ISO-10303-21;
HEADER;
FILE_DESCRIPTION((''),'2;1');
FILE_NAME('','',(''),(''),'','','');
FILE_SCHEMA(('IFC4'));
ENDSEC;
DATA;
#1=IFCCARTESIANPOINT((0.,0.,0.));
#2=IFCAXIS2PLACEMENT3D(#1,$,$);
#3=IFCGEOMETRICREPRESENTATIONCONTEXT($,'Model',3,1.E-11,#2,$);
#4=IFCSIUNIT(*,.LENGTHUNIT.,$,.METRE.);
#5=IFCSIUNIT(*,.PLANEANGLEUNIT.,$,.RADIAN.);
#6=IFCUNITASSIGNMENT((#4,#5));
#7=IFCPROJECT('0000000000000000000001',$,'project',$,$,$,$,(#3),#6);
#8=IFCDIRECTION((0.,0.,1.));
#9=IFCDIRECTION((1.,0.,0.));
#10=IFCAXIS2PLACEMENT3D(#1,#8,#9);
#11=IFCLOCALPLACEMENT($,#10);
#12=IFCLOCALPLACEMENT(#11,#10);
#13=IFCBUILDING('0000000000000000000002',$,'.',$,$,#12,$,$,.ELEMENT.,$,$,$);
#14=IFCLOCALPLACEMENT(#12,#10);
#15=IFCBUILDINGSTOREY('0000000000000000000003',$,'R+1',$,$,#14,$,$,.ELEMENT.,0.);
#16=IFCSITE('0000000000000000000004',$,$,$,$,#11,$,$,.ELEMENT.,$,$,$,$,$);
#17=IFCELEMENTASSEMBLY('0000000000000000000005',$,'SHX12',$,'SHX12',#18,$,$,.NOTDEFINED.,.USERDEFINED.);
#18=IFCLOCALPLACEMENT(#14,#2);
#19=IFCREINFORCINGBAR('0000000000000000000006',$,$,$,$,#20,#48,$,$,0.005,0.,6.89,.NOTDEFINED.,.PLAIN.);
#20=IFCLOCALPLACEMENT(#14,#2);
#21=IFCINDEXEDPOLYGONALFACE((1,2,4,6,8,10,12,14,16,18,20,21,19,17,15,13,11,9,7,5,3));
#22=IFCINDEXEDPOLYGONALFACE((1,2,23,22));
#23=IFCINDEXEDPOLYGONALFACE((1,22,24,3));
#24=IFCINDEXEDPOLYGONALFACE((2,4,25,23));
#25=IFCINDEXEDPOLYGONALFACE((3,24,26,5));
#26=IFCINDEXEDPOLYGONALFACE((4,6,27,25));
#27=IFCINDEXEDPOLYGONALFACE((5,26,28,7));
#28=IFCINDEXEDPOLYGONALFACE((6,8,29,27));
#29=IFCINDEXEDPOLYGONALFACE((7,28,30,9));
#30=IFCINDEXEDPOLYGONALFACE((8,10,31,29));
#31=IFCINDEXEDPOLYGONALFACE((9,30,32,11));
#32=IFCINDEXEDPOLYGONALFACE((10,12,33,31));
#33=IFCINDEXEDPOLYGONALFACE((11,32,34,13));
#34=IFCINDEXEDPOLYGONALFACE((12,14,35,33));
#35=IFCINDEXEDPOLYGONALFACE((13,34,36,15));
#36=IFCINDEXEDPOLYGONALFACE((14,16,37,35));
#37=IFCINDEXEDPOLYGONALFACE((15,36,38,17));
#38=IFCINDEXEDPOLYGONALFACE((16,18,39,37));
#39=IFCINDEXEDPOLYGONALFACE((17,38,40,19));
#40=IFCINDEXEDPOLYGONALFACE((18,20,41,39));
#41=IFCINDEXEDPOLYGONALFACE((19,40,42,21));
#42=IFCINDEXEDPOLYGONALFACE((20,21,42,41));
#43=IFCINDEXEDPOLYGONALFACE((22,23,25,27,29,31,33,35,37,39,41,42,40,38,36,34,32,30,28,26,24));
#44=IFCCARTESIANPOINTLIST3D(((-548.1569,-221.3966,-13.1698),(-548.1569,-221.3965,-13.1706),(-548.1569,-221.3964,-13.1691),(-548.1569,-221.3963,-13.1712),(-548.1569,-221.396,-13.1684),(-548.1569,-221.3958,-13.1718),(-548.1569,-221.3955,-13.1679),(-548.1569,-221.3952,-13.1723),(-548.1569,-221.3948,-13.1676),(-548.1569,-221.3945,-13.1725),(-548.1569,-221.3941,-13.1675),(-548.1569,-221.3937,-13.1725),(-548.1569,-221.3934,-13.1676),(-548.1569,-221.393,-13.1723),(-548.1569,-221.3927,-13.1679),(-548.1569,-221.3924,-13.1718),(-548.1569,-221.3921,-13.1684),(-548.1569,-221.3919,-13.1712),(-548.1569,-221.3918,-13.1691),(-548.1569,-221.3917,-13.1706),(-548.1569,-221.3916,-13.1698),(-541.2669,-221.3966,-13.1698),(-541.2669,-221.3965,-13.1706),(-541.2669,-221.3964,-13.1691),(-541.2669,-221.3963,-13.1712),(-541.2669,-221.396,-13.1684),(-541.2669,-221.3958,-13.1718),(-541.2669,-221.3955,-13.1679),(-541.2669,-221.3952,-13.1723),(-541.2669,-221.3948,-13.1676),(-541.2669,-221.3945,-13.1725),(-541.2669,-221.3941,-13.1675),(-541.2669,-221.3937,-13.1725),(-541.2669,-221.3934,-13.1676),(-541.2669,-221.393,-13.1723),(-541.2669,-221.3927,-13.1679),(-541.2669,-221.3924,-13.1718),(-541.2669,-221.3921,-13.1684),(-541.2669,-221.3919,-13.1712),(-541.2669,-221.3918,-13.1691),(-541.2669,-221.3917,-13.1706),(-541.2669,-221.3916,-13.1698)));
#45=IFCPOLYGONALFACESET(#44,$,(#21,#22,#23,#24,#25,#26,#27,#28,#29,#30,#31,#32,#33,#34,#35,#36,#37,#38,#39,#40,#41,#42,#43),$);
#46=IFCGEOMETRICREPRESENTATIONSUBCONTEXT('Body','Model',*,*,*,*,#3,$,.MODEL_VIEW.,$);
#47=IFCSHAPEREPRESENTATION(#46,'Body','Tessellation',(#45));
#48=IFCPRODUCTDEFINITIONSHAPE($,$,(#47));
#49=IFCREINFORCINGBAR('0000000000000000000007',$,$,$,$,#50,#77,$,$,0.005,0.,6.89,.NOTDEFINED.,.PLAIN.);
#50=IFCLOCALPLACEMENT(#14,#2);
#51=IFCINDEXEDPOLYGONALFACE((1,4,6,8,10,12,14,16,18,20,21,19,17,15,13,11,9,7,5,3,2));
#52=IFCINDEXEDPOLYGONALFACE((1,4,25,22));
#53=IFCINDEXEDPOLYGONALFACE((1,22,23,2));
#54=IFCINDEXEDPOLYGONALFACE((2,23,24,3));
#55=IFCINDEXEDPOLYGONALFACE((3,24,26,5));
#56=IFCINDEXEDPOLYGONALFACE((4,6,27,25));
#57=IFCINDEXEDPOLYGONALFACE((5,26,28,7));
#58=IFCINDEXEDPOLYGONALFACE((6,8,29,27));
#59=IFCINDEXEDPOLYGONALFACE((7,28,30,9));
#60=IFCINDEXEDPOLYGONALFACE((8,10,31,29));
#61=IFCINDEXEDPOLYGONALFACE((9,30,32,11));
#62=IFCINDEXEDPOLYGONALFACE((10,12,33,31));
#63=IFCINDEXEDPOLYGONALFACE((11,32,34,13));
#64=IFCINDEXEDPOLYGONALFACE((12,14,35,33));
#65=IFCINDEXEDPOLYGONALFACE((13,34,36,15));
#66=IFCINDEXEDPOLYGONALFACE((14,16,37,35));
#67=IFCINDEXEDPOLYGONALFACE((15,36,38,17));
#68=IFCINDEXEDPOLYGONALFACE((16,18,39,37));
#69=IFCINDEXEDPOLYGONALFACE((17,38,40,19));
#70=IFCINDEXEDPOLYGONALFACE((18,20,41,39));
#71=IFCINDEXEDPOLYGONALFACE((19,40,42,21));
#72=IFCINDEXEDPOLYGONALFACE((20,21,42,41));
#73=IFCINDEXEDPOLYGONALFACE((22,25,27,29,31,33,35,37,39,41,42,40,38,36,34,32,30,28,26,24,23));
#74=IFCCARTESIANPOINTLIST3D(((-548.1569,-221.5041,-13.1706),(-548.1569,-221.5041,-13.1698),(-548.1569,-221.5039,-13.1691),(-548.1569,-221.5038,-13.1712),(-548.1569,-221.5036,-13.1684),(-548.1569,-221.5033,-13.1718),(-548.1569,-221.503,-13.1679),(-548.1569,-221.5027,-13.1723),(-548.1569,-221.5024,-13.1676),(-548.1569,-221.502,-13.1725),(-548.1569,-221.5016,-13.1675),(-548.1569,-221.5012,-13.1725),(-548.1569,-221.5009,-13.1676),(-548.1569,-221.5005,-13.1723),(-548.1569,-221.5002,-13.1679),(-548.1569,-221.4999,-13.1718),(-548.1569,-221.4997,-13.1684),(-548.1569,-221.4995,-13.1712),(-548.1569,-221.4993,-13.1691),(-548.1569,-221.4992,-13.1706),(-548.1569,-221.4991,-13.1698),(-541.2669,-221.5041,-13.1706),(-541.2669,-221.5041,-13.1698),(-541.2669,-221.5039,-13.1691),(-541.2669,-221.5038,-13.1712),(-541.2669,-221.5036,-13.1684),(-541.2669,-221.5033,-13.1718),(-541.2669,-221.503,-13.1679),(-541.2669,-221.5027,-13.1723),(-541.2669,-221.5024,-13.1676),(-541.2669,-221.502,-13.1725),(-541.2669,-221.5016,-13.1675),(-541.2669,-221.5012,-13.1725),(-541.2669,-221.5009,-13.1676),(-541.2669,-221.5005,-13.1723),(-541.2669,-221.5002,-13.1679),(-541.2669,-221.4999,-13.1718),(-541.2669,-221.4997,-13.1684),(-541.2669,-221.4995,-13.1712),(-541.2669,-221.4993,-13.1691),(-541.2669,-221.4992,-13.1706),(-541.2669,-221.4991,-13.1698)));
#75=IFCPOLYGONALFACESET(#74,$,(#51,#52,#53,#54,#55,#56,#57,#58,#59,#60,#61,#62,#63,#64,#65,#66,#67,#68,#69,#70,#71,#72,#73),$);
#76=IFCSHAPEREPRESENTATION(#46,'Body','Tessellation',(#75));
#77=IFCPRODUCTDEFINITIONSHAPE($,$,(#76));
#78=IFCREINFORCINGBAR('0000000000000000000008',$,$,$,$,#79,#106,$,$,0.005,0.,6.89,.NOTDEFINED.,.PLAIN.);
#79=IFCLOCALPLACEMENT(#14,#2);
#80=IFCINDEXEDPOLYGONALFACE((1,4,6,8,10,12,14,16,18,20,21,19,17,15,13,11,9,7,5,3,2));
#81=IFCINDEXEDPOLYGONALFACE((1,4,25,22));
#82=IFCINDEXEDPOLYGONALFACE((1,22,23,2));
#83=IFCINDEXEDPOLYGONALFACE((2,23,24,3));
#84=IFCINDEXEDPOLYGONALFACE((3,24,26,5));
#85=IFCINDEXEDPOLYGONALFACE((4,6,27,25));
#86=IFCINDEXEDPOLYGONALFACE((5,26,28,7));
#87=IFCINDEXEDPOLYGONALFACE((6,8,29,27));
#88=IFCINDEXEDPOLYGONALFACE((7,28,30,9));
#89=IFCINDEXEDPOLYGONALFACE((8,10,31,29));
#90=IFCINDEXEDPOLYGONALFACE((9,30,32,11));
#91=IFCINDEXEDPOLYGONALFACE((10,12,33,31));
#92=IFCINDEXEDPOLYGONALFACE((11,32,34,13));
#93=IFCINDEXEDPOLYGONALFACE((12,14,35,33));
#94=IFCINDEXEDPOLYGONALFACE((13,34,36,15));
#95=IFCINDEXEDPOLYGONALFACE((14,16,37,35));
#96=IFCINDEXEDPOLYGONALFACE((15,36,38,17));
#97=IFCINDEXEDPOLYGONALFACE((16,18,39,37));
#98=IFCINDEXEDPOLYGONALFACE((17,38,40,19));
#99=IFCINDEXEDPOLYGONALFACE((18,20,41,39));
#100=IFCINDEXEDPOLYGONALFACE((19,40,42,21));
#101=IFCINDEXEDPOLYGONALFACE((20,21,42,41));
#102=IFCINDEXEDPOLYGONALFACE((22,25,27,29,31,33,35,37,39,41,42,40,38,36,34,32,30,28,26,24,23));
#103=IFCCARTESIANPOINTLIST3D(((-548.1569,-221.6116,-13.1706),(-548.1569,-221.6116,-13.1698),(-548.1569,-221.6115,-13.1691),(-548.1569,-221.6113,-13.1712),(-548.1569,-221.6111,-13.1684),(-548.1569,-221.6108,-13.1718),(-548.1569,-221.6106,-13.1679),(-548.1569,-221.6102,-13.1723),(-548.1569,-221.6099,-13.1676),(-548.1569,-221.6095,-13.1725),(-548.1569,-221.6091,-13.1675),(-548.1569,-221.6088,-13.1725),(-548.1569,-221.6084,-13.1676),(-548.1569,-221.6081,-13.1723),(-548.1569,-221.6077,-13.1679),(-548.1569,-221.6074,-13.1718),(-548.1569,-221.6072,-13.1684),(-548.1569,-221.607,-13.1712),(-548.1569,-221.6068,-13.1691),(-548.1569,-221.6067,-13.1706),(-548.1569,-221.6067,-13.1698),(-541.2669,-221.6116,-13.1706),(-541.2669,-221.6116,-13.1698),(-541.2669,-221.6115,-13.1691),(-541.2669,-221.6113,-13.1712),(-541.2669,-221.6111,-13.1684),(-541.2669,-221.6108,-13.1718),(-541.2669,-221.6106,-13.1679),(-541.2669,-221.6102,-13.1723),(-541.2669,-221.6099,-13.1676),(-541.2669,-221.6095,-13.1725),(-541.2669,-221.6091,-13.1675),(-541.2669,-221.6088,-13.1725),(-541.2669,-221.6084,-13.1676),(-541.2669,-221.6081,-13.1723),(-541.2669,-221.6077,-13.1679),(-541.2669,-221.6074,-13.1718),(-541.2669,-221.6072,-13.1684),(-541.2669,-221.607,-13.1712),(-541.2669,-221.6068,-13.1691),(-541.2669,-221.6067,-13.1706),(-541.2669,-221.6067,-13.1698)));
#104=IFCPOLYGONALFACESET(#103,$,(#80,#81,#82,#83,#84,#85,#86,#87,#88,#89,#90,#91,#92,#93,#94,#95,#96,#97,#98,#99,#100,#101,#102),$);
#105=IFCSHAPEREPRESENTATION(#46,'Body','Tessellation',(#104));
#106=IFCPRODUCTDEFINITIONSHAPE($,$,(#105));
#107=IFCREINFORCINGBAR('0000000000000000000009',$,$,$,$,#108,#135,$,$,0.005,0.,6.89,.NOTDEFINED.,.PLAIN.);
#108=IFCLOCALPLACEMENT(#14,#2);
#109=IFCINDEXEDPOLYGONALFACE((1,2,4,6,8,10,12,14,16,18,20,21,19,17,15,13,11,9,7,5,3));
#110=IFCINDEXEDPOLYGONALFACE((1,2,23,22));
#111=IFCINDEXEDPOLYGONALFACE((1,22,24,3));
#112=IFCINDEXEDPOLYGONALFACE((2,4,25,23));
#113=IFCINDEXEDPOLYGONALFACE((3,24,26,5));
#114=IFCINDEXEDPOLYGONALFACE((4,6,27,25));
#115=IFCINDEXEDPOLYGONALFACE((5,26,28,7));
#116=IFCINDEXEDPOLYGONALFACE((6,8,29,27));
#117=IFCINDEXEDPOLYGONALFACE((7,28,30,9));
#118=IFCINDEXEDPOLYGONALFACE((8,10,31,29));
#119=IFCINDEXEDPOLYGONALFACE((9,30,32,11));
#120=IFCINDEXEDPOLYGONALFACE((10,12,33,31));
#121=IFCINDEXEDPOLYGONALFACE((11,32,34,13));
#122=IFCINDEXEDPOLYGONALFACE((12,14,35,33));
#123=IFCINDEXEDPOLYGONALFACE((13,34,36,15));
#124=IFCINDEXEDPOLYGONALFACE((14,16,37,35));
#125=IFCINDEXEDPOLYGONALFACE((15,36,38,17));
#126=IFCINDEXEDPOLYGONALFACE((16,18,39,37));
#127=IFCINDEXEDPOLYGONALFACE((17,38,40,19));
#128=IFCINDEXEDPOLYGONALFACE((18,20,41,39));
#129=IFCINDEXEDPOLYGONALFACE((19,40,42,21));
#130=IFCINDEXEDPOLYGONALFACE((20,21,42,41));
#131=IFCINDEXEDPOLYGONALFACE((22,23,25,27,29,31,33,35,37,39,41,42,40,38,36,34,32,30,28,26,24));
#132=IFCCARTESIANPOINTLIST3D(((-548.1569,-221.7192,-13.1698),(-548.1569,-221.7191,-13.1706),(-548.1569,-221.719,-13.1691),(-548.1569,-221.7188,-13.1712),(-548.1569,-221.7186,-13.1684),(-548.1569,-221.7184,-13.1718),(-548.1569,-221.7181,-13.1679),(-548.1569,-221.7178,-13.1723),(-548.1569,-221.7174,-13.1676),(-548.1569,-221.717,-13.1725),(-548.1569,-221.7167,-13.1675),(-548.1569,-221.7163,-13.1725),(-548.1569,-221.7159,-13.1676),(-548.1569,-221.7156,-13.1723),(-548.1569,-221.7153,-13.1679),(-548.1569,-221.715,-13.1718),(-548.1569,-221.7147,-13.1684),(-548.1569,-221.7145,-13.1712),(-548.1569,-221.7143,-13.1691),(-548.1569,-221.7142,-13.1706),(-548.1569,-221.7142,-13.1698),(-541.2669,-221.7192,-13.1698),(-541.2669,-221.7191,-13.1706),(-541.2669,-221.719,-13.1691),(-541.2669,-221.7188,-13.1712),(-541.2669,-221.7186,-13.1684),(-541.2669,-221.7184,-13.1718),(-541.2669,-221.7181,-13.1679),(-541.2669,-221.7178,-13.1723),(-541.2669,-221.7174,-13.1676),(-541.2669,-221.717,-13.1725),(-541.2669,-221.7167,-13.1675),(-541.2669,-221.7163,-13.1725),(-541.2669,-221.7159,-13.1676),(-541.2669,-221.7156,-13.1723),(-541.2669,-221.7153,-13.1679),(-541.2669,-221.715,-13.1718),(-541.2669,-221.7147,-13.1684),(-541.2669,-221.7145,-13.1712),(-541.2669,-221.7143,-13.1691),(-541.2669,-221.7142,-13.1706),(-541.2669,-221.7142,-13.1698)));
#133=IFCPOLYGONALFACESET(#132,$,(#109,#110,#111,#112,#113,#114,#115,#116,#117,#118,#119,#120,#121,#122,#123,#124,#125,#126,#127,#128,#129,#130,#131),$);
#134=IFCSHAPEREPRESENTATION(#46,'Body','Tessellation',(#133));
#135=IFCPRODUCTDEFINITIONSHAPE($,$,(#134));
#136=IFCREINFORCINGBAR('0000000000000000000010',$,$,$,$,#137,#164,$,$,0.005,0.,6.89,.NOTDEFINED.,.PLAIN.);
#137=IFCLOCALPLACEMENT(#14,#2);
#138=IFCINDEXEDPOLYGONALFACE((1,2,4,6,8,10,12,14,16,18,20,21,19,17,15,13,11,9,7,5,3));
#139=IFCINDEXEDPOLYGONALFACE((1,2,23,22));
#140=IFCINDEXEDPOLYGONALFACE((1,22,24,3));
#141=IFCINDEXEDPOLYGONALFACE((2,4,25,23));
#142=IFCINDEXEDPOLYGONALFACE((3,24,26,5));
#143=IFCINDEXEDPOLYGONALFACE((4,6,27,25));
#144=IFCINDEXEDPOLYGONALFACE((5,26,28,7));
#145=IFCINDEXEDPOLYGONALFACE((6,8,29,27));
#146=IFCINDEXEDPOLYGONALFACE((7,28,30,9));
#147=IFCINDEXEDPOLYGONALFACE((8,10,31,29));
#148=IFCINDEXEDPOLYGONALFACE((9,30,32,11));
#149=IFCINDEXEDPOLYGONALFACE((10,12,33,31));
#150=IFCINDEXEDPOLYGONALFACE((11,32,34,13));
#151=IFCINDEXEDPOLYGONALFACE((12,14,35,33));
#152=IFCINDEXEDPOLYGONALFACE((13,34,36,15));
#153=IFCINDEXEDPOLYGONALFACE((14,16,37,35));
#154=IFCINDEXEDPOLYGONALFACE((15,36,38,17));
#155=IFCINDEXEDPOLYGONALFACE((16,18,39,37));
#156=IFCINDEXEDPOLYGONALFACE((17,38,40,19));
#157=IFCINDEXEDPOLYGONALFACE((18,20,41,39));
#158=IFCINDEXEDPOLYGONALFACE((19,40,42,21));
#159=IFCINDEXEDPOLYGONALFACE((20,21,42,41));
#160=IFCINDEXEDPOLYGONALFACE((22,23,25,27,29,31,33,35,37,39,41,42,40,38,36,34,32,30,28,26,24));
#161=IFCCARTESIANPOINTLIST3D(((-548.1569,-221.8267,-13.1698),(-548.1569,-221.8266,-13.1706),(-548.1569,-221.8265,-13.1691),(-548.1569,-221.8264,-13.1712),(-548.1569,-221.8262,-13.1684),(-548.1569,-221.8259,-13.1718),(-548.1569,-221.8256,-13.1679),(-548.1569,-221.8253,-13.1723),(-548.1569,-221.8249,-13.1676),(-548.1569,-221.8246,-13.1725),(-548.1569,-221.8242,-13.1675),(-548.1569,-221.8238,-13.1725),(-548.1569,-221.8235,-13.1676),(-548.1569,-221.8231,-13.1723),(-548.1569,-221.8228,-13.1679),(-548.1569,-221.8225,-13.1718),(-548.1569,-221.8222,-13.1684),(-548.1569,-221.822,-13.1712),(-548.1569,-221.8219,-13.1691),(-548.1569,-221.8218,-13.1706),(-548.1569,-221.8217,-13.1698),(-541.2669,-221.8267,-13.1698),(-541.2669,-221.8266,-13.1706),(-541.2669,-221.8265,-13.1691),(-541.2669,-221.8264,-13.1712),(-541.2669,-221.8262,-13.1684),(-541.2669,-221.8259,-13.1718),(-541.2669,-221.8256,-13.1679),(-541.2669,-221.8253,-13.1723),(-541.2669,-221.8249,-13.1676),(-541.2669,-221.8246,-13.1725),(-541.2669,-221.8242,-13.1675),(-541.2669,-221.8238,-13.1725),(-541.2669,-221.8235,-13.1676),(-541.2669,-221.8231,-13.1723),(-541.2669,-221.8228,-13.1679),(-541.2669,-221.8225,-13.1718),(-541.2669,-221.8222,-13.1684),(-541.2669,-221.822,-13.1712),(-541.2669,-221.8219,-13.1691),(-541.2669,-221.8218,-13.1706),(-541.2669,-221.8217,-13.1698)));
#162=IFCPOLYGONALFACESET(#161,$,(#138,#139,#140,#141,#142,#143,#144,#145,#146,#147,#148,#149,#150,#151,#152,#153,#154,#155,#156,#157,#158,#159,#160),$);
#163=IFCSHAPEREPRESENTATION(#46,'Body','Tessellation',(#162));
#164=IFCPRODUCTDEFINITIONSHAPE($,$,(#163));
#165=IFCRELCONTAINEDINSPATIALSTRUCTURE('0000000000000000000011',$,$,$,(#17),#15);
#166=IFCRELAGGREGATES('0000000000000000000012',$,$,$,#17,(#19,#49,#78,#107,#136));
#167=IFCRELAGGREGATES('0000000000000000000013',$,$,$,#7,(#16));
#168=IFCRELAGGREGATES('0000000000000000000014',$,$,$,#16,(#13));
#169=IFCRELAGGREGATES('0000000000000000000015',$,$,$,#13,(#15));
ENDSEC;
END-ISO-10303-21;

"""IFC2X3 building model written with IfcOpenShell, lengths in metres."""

from ifc_helpers import new_model, entity, si_unit, origin, origin_with_axes, place, context, subcontext, project, spatial, shape, element, aggregate, save


model = new_model("IFC2X3")

# Units and contexts
model_context = context("Model", 3, precision=1e-11, world=origin())
body_context = subcontext(model_context, "Body", "Model", "MODEL_VIEW")
ifc_project = project(units=[si_unit("LENGTHUNIT", "METRE"), si_unit("PLANEANGLEUNIT", "RADIAN")], contexts=[model_context])

# Site, building, storey
site_placement = place(None, origin_with_axes())
site = spatial("IfcSite", under=ifc_project, at=site_placement, CompositionType="ELEMENT")
building_placement = place(site_placement, origin_with_axes())
building = spatial("IfcBuilding", under=site, at=building_placement, Name=".", CompositionType="ELEMENT")
storey_placement = place(building_placement, origin_with_axes())
storey = spatial("IfcBuildingStorey", under=building, at=storey_placement, Name="R+1", CompositionType="ELEMENT", Elevation=0.0)

# Element assembly, reinforcing bars
assembly_1_placement = place(storey_placement, origin_with_axes())
assembly_1 = element("IfcElementAssembly", 1, at=assembly_1_placement, inside=storey, Name="SHX12", ObjectType="SHX12", AssemblyPlace="NOTDEFINED", PredefinedType="USERDEFINED")
reinforcing_bar_1_placement = place(assembly_1_placement, origin_with_axes())
reinforcing_bar_1 = element("IfcReinforcingBar", 2, at=reinforcing_bar_1_placement, BarLength=6.89, BarRole="NOTDEFINED", BarSurface="PLAIN", CrossSectionArea=0.0, NominalDiameter=0.005, shapes=[
    shape(body_context, "Body", "AdvancedSweptSolid", [entity("IfcSweptDiskSolid", entity("IfcPolyline", [entity("IfcCartesianPoint", [541.2669, 221.3941, 13.17]), entity("IfcCartesianPoint", [548.1569, 221.3941, 13.17])]), 0.0025, None, 0.0, 6.89)]),
    shape(body_context, "Body", "AdvancedSweptSolid", [entity("IfcSweptDiskSolid", entity("IfcPolyline", [entity("IfcCartesianPoint", [541.2669, 221.3941, 13.17]), entity("IfcCartesianPoint", [548.1569, 221.3941, 13.17])]), 0.0025, None, 0.0, 6.89)]),
])
reinforcing_bar_2_placement = place(assembly_1_placement, origin_with_axes())
reinforcing_bar_2 = element("IfcReinforcingBar", 3, at=reinforcing_bar_2_placement, BarLength=6.89, BarRole="NOTDEFINED", BarSurface="PLAIN", CrossSectionArea=0.0, NominalDiameter=0.005, shapes=[
    shape(body_context, "Body", "AdvancedSweptSolid", [entity("IfcSweptDiskSolid", entity("IfcPolyline", [entity("IfcCartesianPoint", [541.2669, 221.5016, 13.17]), entity("IfcCartesianPoint", [548.1569, 221.5016, 13.17])]), 0.0025, None, 0.0, 6.89)]),
    shape(body_context, "Body", "AdvancedSweptSolid", [entity("IfcSweptDiskSolid", entity("IfcPolyline", [entity("IfcCartesianPoint", [541.2669, 221.5016, 13.17]), entity("IfcCartesianPoint", [548.1569, 221.5016, 13.17])]), 0.0025, None, 0.0, 6.89)]),
])
reinforcing_bar_3_placement = place(assembly_1_placement, origin_with_axes())
reinforcing_bar_3 = element("IfcReinforcingBar", 4, at=reinforcing_bar_3_placement, BarLength=6.89, BarRole="NOTDEFINED", BarSurface="PLAIN", CrossSectionArea=0.0, NominalDiameter=0.005, shapes=[
    shape(body_context, "Body", "AdvancedSweptSolid", [entity("IfcSweptDiskSolid", entity("IfcPolyline", [entity("IfcCartesianPoint", [541.2669, 221.6091, 13.17]), entity("IfcCartesianPoint", [548.1569, 221.6091, 13.17])]), 0.0025, None, 0.0, 6.89)]),
    shape(body_context, "Body", "AdvancedSweptSolid", [entity("IfcSweptDiskSolid", entity("IfcPolyline", [entity("IfcCartesianPoint", [541.2669, 221.6091, 13.17]), entity("IfcCartesianPoint", [548.1569, 221.6091, 13.17])]), 0.0025, None, 0.0, 6.89)]),
])
reinforcing_bar_4_placement = place(assembly_1_placement, origin_with_axes())
reinforcing_bar_4 = element("IfcReinforcingBar", 5, at=reinforcing_bar_4_placement, BarLength=6.89, BarRole="NOTDEFINED", BarSurface="PLAIN", CrossSectionArea=0.0, NominalDiameter=0.005, shapes=[
    shape(body_context, "Body", "AdvancedSweptSolid", [entity("IfcSweptDiskSolid", entity("IfcPolyline", [entity("IfcCartesianPoint", [541.2669, 221.7167, 13.17]), entity("IfcCartesianPoint", [548.1569, 221.7167, 13.17])]), 0.0025, None, 0.0, 6.89)]),
    shape(body_context, "Body", "AdvancedSweptSolid", [entity("IfcSweptDiskSolid", entity("IfcPolyline", [entity("IfcCartesianPoint", [541.2669, 221.7167, 13.17]), entity("IfcCartesianPoint", [548.1569, 221.7167, 13.17])]), 0.0025, None, 0.0, 6.89)]),
])
reinforcing_bar_5_placement = place(assembly_1_placement, origin_with_axes())
reinforcing_bar_5 = element("IfcReinforcingBar", 6, at=reinforcing_bar_5_placement, BarLength=6.89, BarRole="NOTDEFINED", BarSurface="PLAIN", CrossSectionArea=0.0, NominalDiameter=0.005, shapes=[
    shape(body_context, "Body", "AdvancedSweptSolid", [entity("IfcSweptDiskSolid", entity("IfcPolyline", [entity("IfcCartesianPoint", [541.2669, 221.8242, 13.17]), entity("IfcCartesianPoint", [548.1569, 221.8242, 13.17])]), 0.0025, None, 0.0, 6.89)]),
    shape(body_context, "Body", "AdvancedSweptSolid", [entity("IfcSweptDiskSolid", entity("IfcPolyline", [entity("IfcCartesianPoint", [541.2669, 221.8242, 13.17]), entity("IfcCartesianPoint", [548.1569, 221.8242, 13.17])]), 0.0025, None, 0.0, 6.89)]),
])
aggregate(assembly_1, [reinforcing_bar_1, reinforcing_bar_2, reinforcing_bar_3, reinforcing_bar_4, reinforcing_bar_5])

save(model, "model.ifc")
